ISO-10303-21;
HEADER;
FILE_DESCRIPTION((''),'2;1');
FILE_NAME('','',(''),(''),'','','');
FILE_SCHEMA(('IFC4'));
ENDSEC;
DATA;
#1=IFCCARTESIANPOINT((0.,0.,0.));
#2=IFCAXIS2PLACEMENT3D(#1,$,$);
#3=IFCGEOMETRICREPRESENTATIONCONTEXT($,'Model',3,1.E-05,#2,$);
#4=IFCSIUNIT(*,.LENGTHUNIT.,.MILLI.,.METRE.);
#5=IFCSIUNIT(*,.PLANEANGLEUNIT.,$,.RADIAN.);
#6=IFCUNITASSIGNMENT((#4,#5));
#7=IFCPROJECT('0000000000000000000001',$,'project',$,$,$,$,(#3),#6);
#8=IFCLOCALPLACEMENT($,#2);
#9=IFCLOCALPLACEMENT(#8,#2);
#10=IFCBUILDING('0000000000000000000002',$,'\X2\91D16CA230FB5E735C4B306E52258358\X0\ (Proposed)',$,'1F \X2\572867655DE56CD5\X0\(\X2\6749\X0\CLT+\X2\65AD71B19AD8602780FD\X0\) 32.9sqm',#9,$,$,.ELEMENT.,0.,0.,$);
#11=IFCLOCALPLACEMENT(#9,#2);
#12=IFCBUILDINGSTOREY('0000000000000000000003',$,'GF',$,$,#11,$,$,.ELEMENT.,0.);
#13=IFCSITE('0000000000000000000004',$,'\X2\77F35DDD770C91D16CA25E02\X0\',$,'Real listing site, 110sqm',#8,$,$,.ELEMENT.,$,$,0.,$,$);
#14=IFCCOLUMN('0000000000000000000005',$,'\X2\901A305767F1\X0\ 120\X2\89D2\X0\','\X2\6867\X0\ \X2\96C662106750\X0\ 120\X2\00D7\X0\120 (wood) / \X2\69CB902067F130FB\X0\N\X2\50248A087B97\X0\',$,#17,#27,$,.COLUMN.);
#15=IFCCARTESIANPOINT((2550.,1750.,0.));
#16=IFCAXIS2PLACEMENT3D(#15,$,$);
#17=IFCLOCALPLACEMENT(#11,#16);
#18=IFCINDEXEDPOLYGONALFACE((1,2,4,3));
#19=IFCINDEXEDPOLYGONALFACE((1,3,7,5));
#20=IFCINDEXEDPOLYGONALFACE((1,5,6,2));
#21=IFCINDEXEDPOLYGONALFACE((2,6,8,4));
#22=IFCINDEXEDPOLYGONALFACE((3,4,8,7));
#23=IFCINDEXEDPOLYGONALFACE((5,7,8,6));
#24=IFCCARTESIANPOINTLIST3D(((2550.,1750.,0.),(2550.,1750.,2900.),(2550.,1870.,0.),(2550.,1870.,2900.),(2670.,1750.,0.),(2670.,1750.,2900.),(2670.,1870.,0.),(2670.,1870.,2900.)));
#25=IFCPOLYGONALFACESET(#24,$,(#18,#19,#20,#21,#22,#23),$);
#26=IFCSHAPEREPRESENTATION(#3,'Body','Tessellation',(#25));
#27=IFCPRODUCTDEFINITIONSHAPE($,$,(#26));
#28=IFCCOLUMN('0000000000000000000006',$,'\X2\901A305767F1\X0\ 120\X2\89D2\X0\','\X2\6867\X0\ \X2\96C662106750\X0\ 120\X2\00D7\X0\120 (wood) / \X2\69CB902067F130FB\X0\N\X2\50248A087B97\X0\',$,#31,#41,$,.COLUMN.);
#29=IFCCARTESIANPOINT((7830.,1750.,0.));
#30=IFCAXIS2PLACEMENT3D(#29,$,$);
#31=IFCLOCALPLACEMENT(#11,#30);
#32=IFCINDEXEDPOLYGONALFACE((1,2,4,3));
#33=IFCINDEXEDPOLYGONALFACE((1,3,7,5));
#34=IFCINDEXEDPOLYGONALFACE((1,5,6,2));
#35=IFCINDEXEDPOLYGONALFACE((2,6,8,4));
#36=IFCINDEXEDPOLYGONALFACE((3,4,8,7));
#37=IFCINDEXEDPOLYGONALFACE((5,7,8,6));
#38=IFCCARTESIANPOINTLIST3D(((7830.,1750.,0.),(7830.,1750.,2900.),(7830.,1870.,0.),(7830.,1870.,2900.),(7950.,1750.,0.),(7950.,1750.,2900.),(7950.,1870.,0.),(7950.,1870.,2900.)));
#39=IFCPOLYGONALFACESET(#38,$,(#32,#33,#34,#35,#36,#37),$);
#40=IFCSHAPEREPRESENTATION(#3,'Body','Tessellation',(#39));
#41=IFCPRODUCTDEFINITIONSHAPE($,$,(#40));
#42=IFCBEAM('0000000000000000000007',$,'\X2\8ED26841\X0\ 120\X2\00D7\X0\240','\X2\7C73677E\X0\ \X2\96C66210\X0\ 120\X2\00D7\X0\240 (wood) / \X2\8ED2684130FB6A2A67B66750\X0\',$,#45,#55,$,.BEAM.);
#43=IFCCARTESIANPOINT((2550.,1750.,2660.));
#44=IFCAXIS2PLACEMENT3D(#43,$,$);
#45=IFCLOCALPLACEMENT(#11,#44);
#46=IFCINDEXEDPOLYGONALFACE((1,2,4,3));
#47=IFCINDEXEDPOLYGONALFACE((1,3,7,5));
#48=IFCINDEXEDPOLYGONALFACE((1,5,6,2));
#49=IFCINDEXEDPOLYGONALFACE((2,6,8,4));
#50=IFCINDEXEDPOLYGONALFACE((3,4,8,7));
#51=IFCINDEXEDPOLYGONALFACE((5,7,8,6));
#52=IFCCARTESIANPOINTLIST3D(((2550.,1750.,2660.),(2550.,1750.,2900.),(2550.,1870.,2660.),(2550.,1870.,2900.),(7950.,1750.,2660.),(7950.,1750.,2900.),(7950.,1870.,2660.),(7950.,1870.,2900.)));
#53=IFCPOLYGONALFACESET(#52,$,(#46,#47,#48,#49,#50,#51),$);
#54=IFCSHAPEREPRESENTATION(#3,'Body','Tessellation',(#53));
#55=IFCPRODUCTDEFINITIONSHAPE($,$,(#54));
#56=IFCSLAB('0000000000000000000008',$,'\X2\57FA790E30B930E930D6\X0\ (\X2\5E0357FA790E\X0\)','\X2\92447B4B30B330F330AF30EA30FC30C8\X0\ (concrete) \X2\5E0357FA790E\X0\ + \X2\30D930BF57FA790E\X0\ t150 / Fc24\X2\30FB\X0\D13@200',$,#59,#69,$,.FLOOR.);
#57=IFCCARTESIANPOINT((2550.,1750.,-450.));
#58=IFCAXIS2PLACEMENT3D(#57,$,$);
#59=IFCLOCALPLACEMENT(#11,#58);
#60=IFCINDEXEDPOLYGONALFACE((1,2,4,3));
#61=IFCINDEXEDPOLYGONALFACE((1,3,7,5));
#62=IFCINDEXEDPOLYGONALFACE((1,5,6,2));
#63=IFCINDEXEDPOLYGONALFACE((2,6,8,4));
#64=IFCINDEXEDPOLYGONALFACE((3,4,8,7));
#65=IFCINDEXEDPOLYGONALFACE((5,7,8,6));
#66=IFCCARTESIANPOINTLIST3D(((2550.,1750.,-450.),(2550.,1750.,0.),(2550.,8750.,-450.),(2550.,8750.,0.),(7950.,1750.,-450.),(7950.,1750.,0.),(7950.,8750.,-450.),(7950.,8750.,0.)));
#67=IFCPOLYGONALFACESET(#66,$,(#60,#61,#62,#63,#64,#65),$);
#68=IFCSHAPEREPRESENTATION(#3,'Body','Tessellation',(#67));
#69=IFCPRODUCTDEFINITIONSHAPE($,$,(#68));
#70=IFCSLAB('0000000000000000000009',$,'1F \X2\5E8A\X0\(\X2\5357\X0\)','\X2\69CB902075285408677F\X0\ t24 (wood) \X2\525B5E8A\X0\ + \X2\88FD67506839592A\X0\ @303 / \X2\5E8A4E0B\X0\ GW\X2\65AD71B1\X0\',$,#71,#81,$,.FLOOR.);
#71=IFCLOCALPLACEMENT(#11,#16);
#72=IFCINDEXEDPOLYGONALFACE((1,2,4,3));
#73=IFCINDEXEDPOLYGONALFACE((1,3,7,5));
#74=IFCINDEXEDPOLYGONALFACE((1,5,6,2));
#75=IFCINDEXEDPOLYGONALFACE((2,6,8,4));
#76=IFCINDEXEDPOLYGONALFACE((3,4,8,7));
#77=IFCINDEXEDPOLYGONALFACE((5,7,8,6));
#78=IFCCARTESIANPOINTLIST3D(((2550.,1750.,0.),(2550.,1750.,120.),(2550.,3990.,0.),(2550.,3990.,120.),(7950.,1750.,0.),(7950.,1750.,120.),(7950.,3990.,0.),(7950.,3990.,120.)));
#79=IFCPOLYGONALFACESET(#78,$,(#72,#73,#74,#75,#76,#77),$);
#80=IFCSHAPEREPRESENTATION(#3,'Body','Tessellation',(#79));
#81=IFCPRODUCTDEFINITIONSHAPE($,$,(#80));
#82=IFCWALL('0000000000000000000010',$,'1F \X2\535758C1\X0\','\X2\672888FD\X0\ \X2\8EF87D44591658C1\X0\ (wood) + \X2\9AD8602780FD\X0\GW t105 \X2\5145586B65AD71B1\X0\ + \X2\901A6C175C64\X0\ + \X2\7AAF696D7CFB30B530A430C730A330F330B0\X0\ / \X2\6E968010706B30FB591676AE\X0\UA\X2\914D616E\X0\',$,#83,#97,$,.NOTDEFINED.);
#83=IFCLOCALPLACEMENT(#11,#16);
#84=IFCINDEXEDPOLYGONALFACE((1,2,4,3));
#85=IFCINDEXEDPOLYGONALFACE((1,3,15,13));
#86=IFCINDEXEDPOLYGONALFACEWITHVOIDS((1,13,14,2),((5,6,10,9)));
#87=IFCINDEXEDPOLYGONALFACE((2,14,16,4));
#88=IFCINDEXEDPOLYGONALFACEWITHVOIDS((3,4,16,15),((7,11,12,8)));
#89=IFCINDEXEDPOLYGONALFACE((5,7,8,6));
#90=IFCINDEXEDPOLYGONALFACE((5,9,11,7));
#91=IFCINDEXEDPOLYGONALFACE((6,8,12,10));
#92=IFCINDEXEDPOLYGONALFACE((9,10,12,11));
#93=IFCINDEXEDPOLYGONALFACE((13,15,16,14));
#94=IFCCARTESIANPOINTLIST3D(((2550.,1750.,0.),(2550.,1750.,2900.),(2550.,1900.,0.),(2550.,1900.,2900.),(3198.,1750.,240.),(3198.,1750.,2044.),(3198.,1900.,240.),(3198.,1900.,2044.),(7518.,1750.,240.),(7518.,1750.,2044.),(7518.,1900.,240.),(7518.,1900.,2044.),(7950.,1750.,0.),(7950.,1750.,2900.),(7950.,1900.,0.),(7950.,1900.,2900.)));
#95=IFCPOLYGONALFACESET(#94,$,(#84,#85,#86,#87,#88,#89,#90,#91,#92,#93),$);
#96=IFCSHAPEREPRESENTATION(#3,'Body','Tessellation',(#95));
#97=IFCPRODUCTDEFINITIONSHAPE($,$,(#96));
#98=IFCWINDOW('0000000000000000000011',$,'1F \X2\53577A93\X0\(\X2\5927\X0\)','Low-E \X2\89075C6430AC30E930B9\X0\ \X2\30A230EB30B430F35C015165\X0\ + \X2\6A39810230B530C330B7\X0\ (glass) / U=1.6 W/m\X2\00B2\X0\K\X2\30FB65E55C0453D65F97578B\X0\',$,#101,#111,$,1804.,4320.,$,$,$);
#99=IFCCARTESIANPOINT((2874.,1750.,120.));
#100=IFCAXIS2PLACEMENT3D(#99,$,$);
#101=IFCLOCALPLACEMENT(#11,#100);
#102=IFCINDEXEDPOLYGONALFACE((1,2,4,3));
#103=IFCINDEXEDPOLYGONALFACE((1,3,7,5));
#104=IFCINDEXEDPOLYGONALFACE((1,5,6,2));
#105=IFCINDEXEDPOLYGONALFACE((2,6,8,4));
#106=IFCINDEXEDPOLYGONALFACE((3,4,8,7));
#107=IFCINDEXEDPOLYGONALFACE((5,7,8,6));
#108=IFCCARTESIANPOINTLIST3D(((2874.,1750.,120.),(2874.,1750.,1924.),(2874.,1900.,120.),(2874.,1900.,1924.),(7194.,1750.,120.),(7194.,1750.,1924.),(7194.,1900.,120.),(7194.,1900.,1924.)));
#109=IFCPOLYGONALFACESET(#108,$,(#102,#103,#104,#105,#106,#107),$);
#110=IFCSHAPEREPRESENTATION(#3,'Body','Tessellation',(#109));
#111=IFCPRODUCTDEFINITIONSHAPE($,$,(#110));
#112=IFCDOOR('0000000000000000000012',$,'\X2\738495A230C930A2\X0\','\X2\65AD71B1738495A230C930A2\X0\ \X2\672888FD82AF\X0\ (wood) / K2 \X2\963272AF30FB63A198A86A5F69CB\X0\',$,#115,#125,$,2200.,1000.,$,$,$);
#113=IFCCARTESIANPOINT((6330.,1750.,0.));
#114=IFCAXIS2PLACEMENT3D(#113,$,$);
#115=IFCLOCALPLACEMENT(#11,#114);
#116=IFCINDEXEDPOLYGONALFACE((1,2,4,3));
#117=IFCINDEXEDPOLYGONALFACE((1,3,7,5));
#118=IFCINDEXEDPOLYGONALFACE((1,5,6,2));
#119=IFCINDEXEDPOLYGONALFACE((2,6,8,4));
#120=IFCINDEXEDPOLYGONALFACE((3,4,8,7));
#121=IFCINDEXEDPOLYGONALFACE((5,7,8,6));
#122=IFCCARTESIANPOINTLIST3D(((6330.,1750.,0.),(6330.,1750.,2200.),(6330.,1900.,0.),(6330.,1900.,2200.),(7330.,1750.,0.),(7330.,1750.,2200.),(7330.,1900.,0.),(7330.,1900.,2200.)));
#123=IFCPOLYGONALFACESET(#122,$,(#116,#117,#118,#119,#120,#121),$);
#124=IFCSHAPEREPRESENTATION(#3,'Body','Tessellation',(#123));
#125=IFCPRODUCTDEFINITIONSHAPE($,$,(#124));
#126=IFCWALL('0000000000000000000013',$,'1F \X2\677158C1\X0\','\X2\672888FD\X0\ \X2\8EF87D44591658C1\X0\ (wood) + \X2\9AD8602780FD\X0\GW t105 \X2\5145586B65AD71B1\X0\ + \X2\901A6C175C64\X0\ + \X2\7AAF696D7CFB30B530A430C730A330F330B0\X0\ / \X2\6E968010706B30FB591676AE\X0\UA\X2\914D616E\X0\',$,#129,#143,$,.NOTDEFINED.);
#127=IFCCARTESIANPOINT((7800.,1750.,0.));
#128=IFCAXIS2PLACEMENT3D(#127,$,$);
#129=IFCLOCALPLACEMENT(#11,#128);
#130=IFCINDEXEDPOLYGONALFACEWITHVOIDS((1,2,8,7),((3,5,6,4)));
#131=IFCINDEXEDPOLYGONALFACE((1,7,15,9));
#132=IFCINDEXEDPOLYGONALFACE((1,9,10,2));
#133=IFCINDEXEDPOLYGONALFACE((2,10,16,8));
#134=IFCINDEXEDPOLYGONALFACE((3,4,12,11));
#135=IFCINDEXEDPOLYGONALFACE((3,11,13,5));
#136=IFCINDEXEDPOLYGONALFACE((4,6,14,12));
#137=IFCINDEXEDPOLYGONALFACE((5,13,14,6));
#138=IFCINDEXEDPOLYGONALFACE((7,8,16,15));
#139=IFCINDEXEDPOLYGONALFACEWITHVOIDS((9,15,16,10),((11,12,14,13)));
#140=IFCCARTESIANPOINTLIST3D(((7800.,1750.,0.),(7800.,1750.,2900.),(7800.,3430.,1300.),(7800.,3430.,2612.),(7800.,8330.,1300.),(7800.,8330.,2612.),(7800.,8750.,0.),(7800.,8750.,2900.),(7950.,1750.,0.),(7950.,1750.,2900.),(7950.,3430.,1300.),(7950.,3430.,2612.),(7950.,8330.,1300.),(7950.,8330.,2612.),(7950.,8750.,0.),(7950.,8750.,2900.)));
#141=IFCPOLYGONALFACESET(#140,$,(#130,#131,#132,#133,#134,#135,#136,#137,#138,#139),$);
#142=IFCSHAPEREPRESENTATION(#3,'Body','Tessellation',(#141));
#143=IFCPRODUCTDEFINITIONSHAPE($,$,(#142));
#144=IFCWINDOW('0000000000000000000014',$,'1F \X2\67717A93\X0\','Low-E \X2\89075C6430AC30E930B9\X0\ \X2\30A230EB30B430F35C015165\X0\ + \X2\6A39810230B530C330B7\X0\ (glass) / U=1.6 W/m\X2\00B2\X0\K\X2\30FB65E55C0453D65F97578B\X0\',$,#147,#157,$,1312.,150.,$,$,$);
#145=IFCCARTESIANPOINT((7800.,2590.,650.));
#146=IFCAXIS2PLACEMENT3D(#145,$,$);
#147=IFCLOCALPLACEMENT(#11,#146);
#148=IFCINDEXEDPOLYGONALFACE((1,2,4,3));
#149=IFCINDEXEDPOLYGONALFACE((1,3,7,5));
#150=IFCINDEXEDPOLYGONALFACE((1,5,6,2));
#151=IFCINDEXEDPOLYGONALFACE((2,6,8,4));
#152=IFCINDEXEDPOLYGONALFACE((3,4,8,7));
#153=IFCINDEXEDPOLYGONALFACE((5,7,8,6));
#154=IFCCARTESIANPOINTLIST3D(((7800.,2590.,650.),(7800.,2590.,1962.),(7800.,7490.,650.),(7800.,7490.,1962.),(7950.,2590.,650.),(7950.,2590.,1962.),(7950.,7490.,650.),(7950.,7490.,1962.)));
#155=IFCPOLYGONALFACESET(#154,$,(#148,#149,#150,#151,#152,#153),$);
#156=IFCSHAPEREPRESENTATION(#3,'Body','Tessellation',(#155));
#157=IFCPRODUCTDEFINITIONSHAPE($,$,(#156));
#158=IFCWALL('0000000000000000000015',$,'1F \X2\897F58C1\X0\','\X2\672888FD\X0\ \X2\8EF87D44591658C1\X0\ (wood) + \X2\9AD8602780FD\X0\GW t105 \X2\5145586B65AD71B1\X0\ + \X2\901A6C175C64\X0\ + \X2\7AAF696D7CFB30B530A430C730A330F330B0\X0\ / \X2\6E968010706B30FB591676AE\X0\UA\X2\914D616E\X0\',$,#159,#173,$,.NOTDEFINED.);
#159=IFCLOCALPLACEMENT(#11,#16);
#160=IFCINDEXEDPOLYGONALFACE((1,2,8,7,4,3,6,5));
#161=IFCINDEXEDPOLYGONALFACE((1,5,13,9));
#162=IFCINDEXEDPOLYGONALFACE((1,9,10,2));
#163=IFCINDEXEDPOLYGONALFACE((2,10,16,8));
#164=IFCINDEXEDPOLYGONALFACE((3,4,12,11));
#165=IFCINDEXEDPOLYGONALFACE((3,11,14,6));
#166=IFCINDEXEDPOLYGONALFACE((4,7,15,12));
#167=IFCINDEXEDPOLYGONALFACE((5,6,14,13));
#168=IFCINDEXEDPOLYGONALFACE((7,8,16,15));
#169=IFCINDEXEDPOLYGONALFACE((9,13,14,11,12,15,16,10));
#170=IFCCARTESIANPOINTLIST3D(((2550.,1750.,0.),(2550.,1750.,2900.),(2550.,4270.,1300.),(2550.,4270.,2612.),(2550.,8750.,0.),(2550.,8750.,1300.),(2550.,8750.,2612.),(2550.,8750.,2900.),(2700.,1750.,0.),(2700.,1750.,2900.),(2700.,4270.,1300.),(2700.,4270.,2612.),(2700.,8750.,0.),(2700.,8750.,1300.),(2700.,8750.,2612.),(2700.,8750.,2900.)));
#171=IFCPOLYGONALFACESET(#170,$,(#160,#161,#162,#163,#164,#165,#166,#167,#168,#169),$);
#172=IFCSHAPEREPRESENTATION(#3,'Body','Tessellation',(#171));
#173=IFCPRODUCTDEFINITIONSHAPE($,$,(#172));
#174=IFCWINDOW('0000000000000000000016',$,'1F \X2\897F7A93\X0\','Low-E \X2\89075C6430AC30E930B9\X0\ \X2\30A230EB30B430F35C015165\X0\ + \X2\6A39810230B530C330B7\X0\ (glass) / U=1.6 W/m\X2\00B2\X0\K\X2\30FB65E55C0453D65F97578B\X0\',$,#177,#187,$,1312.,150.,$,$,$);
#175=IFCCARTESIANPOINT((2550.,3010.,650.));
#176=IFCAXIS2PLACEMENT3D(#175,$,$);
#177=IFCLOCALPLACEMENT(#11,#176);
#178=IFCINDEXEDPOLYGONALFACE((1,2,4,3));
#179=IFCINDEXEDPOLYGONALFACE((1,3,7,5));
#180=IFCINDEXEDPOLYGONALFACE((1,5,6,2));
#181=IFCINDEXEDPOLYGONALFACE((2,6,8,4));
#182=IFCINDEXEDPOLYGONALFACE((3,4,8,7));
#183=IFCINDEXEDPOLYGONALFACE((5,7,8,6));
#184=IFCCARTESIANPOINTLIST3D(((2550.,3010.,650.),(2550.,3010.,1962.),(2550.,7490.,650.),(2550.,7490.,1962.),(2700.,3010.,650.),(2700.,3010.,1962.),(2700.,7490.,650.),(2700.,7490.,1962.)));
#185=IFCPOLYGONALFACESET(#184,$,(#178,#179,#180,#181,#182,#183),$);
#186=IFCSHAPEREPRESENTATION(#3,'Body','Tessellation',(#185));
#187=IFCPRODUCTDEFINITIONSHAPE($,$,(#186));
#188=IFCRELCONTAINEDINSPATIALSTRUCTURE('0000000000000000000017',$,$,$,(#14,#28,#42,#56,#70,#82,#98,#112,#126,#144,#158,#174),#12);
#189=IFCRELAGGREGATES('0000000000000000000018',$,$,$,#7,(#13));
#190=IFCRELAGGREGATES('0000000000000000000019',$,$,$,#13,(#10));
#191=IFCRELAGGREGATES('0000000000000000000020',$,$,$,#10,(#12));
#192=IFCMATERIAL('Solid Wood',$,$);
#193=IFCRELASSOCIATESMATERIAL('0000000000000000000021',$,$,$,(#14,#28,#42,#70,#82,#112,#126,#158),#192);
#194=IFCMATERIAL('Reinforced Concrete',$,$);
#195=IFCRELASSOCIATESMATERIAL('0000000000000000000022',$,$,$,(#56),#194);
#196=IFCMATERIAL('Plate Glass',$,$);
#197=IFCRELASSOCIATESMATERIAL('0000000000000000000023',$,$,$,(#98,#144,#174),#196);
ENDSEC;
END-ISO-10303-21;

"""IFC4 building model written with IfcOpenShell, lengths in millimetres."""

from ifc_helpers import new_model, si_unit, frame, frame_2d, origin, place, context, project, spatial, rectangle, extrude, material, element, fill, save


model = new_model("IFC4")

# Units and contexts
model_context = context("Model", 3, precision=1e-05, world=origin())
ifc_project = project(units=[si_unit("LENGTHUNIT", "METRE", prefix="MILLI"), si_unit("PLANEANGLEUNIT", "RADIAN")], contexts=[model_context])

# Site, building, storey
site_placement = place(None, origin())
site = spatial("IfcSite", under=ifc_project, at=site_placement, Name="石川県金沢市", ObjectType="Real listing site, 110sqm", CompositionType="ELEMENT", RefElevation=0.0)
building_placement = place(site_placement, origin())
building = spatial("IfcBuilding", under=site, at=building_placement, Name="金沢・平屋の別荘 (Proposed)", ObjectType="1F 在来工法(杉CLT+断熱高性能) 32.9sqm", CompositionType="ELEMENT", ElevationOfRefHeight=0.0, ElevationOfTerrain=0.0)
storey_placement = place(building_placement, origin())
storey = spatial("IfcBuildingStorey", under=building, at=storey_placement, Name="GF", CompositionType="ELEMENT", Elevation=0.0)

# Columns
ifc_material_1 = material(Name="Solid Wood")
column_1_placement = place(storey_placement, frame((2550.0, 1750.0, 0.0)))
element("IfcColumn", 1, at=column_1_placement, inside=storey, material=ifc_material_1, Name="通し柱 120角", Description="桧 集成材 120×120 (wood) / 構造柱・N値計算", PredefinedType="COLUMN", context=model_context, shape_type="SweptSolid", body=[
    extrude(rectangle(XDim=120.0, YDim=120.0, at=frame_2d((60.0, 60.0))), frame((2550.0, 1750.0, 0.0)), (0.0, 0.0, 1.0), 2900.0),
])
column_2_placement = place(storey_placement, frame((7830.0, 1750.0, 0.0)))
element("IfcColumn", 2, at=column_2_placement, inside=storey, material=ifc_material_1, Name="通し柱 120角", Description="桧 集成材 120×120 (wood) / 構造柱・N値計算", PredefinedType="COLUMN", context=model_context, shape_type="SweptSolid", body=[
    extrude(rectangle(XDim=120.0, YDim=120.0, at=frame_2d((60.0, 60.0))), frame((7830.0, 1750.0, 0.0)), (0.0, 0.0, 1.0), 2900.0),
])

# Beam
beam_1_placement = place(storey_placement, frame((2550.0, 1750.0, 2660.0)))
element("IfcBeam", 3, at=beam_1_placement, inside=storey, material=ifc_material_1, Name="軒桁 120×240", Description="米松 集成 120×240 (wood) / 軒桁・横架材", PredefinedType="BEAM", context=model_context, shape_type="SweptSolid", body=[
    extrude(rectangle(XDim=5400.0, YDim=120.0, at=frame_2d((2700.0, 60.0))), frame((2550.0, 1750.0, 2660.0)), (0.0, 0.0, 1.0), 240.0),
])

# Slabs
ifc_material_2 = material(Name="Reinforced Concrete")
slab_1_placement = place(storey_placement, frame((2550.0, 1750.0, -450.0)))
element("IfcSlab", 4, at=slab_1_placement, inside=storey, material=ifc_material_2, Name="基礎スラブ (布基礎)", Description="鉄筋コンクリート (concrete) 布基礎 + ベタ基礎 t150 / Fc24・D13@200", PredefinedType="FLOOR", context=model_context, shape_type="SweptSolid", body=[
    extrude(rectangle(XDim=5400.0, YDim=7000.0, at=frame_2d((2700.0, 3500.0))), frame((2550.0, 1750.0, -450.0)), (0.0, 0.0, 1.0), 450.0),
])
slab_2_placement = place(storey_placement, frame((2550.0, 1750.0, 0.0)))
element("IfcSlab", 5, at=slab_2_placement, inside=storey, material=ifc_material_1, Name="1F 床(南)", Description="構造用合板 t24 (wood) 剛床 + 製材根太 @303 / 床下 GW断熱", PredefinedType="FLOOR", context=model_context, shape_type="SweptSolid", body=[
    extrude(rectangle(XDim=5400.0, YDim=2240.0, at=frame_2d((2700.0, 1120.0))), frame((2550.0, 1750.0, 0.0)), (0.0, 0.0, 1.0), 120.0),
])

# Wall, openings, window, door
wall_1_placement = place(storey_placement, frame((2550.0, 1750.0, 0.0)))
wall_1 = element("IfcWall", 6, at=wall_1_placement, inside=storey, material=ifc_material_1, Name="1F 南壁", Description="木製 軸組外壁 (wood) + 高性能GW t105 充填断熱 + 通気層 + 窯業系サイディング / 準耐火・外皮UA配慮", PredefinedType="NOTDEFINED", context=model_context, shape_type="SweptSolid", body=[
    extrude(rectangle(XDim=5400.0, YDim=150.0, at=frame_2d((2700.0, 75.0))), frame((2550.0, 1750.0, 0.0)), (0.0, 0.0, 1.0), 2900.0),
])
opening_1_placement = place(storey_placement, frame((2874.0, 1750.0, 120.0)))
opening_1 = element("IfcOpeningElement", 7, at=opening_1_placement, cuts=wall_1, PredefinedType="NOTDEFINED", context=model_context, shape_type="SweptSolid", body=[
    extrude(rectangle(XDim=4320.0, YDim=150.0, at=frame_2d((2160.0, 75.0))), frame((2874.0, 1750.0, 120.0)), (0.0, 0.0, 1.0), 1804.0),
])
opening_2_placement = place(storey_placement, frame((6330.0, 1750.0, 0.0)))
opening_2 = element("IfcOpeningElement", 8, at=opening_2_placement, cuts=wall_1, PredefinedType="NOTDEFINED", context=model_context, shape_type="SweptSolid", body=[
    extrude(rectangle(XDim=1000.0, YDim=150.0, at=frame_2d((500.0, 75.0))), frame((6330.0, 1750.0, 0.0)), (0.0, 0.0, 1.0), 2200.0),
])
ifc_material_3 = material(Name="Plate Glass")
window_1_placement = place(storey_placement, frame((2874.0, 1750.0, 120.0)))
window_1 = element("IfcWindow", 9, at=window_1_placement, inside=storey, material=ifc_material_3, Name="1F 南窓(大)", Description="Low-E 複層ガラス アルゴン封入 + 樹脂サッシ (glass) / U=1.6 W/m²K・日射取得型", OverallHeight=1804.0, OverallWidth=4320.0, context=model_context, shape_type="SweptSolid", body=[
    extrude(rectangle(XDim=4320.0, YDim=150.0, at=frame_2d((2160.0, 75.0))), frame((2874.0, 1750.0, 120.0)), (0.0, 0.0, 1.0), 1804.0),
])
fill(opening_1, window_1)
door_placement = place(storey_placement, frame((6330.0, 1750.0, 0.0)))
door = element("IfcDoor", 10, at=door_placement, inside=storey, material=ifc_material_1, Name="玄関ドア", Description="断熱玄関ドア 木製芯 (wood) / K2 防犯・採風機構", OverallHeight=2200.0, OverallWidth=1000.0, context=model_context, shape_type="SweptSolid", body=[
    extrude(rectangle(XDim=1000.0, YDim=150.0, at=frame_2d((500.0, 75.0))), frame((6330.0, 1750.0, 0.0)), (0.0, 0.0, 1.0), 2200.0),
])
fill(opening_2, door)

# Walls, openings, windows
wall_2_placement = place(storey_placement, frame((7800.0, 1750.0, 0.0)))
wall_2 = element("IfcWall", 11, at=wall_2_placement, inside=storey, material=ifc_material_1, Name="1F 東壁", Description="木製 軸組外壁 (wood) + 高性能GW t105 充填断熱 + 通気層 + 窯業系サイディング / 準耐火・外皮UA配慮", PredefinedType="NOTDEFINED", context=model_context, shape_type="SweptSolid", body=[
    extrude(rectangle(XDim=150.0, YDim=7000.0, at=frame_2d((75.0, 3500.0))), frame((7800.0, 1750.0, 0.0)), (0.0, 0.0, 1.0), 2900.0),
])
opening_3_placement = place(storey_placement, frame((7800.0, 2590.0, 650.0)))
opening_3 = element("IfcOpeningElement", 12, at=opening_3_placement, cuts=wall_2, PredefinedType="NOTDEFINED", context=model_context, shape_type="SweptSolid", body=[
    extrude(rectangle(XDim=150.0, YDim=4900.0, at=frame_2d((75.0, 2450.0))), frame((7800.0, 2590.0, 650.0)), (0.0, 0.0, 1.0), 1312.0),
])
window_2_placement = place(storey_placement, frame((7800.0, 2590.0, 650.0)))
window_2 = element("IfcWindow", 13, at=window_2_placement, inside=storey, material=ifc_material_3, Name="1F 東窓", Description="Low-E 複層ガラス アルゴン封入 + 樹脂サッシ (glass) / U=1.6 W/m²K・日射取得型", OverallHeight=1312.0, OverallWidth=150.0, context=model_context, shape_type="SweptSolid", body=[
    extrude(rectangle(XDim=150.0, YDim=4900.0, at=frame_2d((75.0, 2450.0))), frame((7800.0, 2590.0, 650.0)), (0.0, 0.0, 1.0), 1312.0),
])
fill(opening_3, window_2)
wall_3_placement = place(storey_placement, frame((2550.0, 1750.0, 0.0)))
wall_3 = element("IfcWall", 14, at=wall_3_placement, inside=storey, material=ifc_material_1, Name="1F 西壁", Description="木製 軸組外壁 (wood) + 高性能GW t105 充填断熱 + 通気層 + 窯業系サイディング / 準耐火・外皮UA配慮", PredefinedType="NOTDEFINED", context=model_context, shape_type="SweptSolid", body=[
    extrude(rectangle(XDim=150.0, YDim=7000.0, at=frame_2d((75.0, 3500.0))), frame((2550.0, 1750.0, 0.0)), (0.0, 0.0, 1.0), 2900.0),
])
opening_4_placement = place(storey_placement, frame((2550.0, 3010.0, 650.0)))
opening_4 = element("IfcOpeningElement", 15, at=opening_4_placement, cuts=wall_3, PredefinedType="NOTDEFINED", context=model_context, shape_type="SweptSolid", body=[
    extrude(rectangle(XDim=150.0, YDim=4480.0, at=frame_2d((75.0, 2240.0))), frame((2550.0, 3010.0, 650.0)), (0.0, 0.0, 1.0), 1312.0),
])
window_3_placement = place(storey_placement, frame((2550.0, 3010.0, 650.0)))
window_3 = element("IfcWindow", 16, at=window_3_placement, inside=storey, material=ifc_material_3, Name="1F 西窓", Description="Low-E 複層ガラス アルゴン封入 + 樹脂サッシ (glass) / U=1.6 W/m²K・日射取得型", OverallHeight=1312.0, OverallWidth=150.0, context=model_context, shape_type="SweptSolid", body=[
    extrude(rectangle(XDim=150.0, YDim=4480.0, at=frame_2d((75.0, 2240.0))), frame((2550.0, 3010.0, 650.0)), (0.0, 0.0, 1.0), 1312.0),
])
fill(opening_4, window_3)

save(model, "model.ifc")
